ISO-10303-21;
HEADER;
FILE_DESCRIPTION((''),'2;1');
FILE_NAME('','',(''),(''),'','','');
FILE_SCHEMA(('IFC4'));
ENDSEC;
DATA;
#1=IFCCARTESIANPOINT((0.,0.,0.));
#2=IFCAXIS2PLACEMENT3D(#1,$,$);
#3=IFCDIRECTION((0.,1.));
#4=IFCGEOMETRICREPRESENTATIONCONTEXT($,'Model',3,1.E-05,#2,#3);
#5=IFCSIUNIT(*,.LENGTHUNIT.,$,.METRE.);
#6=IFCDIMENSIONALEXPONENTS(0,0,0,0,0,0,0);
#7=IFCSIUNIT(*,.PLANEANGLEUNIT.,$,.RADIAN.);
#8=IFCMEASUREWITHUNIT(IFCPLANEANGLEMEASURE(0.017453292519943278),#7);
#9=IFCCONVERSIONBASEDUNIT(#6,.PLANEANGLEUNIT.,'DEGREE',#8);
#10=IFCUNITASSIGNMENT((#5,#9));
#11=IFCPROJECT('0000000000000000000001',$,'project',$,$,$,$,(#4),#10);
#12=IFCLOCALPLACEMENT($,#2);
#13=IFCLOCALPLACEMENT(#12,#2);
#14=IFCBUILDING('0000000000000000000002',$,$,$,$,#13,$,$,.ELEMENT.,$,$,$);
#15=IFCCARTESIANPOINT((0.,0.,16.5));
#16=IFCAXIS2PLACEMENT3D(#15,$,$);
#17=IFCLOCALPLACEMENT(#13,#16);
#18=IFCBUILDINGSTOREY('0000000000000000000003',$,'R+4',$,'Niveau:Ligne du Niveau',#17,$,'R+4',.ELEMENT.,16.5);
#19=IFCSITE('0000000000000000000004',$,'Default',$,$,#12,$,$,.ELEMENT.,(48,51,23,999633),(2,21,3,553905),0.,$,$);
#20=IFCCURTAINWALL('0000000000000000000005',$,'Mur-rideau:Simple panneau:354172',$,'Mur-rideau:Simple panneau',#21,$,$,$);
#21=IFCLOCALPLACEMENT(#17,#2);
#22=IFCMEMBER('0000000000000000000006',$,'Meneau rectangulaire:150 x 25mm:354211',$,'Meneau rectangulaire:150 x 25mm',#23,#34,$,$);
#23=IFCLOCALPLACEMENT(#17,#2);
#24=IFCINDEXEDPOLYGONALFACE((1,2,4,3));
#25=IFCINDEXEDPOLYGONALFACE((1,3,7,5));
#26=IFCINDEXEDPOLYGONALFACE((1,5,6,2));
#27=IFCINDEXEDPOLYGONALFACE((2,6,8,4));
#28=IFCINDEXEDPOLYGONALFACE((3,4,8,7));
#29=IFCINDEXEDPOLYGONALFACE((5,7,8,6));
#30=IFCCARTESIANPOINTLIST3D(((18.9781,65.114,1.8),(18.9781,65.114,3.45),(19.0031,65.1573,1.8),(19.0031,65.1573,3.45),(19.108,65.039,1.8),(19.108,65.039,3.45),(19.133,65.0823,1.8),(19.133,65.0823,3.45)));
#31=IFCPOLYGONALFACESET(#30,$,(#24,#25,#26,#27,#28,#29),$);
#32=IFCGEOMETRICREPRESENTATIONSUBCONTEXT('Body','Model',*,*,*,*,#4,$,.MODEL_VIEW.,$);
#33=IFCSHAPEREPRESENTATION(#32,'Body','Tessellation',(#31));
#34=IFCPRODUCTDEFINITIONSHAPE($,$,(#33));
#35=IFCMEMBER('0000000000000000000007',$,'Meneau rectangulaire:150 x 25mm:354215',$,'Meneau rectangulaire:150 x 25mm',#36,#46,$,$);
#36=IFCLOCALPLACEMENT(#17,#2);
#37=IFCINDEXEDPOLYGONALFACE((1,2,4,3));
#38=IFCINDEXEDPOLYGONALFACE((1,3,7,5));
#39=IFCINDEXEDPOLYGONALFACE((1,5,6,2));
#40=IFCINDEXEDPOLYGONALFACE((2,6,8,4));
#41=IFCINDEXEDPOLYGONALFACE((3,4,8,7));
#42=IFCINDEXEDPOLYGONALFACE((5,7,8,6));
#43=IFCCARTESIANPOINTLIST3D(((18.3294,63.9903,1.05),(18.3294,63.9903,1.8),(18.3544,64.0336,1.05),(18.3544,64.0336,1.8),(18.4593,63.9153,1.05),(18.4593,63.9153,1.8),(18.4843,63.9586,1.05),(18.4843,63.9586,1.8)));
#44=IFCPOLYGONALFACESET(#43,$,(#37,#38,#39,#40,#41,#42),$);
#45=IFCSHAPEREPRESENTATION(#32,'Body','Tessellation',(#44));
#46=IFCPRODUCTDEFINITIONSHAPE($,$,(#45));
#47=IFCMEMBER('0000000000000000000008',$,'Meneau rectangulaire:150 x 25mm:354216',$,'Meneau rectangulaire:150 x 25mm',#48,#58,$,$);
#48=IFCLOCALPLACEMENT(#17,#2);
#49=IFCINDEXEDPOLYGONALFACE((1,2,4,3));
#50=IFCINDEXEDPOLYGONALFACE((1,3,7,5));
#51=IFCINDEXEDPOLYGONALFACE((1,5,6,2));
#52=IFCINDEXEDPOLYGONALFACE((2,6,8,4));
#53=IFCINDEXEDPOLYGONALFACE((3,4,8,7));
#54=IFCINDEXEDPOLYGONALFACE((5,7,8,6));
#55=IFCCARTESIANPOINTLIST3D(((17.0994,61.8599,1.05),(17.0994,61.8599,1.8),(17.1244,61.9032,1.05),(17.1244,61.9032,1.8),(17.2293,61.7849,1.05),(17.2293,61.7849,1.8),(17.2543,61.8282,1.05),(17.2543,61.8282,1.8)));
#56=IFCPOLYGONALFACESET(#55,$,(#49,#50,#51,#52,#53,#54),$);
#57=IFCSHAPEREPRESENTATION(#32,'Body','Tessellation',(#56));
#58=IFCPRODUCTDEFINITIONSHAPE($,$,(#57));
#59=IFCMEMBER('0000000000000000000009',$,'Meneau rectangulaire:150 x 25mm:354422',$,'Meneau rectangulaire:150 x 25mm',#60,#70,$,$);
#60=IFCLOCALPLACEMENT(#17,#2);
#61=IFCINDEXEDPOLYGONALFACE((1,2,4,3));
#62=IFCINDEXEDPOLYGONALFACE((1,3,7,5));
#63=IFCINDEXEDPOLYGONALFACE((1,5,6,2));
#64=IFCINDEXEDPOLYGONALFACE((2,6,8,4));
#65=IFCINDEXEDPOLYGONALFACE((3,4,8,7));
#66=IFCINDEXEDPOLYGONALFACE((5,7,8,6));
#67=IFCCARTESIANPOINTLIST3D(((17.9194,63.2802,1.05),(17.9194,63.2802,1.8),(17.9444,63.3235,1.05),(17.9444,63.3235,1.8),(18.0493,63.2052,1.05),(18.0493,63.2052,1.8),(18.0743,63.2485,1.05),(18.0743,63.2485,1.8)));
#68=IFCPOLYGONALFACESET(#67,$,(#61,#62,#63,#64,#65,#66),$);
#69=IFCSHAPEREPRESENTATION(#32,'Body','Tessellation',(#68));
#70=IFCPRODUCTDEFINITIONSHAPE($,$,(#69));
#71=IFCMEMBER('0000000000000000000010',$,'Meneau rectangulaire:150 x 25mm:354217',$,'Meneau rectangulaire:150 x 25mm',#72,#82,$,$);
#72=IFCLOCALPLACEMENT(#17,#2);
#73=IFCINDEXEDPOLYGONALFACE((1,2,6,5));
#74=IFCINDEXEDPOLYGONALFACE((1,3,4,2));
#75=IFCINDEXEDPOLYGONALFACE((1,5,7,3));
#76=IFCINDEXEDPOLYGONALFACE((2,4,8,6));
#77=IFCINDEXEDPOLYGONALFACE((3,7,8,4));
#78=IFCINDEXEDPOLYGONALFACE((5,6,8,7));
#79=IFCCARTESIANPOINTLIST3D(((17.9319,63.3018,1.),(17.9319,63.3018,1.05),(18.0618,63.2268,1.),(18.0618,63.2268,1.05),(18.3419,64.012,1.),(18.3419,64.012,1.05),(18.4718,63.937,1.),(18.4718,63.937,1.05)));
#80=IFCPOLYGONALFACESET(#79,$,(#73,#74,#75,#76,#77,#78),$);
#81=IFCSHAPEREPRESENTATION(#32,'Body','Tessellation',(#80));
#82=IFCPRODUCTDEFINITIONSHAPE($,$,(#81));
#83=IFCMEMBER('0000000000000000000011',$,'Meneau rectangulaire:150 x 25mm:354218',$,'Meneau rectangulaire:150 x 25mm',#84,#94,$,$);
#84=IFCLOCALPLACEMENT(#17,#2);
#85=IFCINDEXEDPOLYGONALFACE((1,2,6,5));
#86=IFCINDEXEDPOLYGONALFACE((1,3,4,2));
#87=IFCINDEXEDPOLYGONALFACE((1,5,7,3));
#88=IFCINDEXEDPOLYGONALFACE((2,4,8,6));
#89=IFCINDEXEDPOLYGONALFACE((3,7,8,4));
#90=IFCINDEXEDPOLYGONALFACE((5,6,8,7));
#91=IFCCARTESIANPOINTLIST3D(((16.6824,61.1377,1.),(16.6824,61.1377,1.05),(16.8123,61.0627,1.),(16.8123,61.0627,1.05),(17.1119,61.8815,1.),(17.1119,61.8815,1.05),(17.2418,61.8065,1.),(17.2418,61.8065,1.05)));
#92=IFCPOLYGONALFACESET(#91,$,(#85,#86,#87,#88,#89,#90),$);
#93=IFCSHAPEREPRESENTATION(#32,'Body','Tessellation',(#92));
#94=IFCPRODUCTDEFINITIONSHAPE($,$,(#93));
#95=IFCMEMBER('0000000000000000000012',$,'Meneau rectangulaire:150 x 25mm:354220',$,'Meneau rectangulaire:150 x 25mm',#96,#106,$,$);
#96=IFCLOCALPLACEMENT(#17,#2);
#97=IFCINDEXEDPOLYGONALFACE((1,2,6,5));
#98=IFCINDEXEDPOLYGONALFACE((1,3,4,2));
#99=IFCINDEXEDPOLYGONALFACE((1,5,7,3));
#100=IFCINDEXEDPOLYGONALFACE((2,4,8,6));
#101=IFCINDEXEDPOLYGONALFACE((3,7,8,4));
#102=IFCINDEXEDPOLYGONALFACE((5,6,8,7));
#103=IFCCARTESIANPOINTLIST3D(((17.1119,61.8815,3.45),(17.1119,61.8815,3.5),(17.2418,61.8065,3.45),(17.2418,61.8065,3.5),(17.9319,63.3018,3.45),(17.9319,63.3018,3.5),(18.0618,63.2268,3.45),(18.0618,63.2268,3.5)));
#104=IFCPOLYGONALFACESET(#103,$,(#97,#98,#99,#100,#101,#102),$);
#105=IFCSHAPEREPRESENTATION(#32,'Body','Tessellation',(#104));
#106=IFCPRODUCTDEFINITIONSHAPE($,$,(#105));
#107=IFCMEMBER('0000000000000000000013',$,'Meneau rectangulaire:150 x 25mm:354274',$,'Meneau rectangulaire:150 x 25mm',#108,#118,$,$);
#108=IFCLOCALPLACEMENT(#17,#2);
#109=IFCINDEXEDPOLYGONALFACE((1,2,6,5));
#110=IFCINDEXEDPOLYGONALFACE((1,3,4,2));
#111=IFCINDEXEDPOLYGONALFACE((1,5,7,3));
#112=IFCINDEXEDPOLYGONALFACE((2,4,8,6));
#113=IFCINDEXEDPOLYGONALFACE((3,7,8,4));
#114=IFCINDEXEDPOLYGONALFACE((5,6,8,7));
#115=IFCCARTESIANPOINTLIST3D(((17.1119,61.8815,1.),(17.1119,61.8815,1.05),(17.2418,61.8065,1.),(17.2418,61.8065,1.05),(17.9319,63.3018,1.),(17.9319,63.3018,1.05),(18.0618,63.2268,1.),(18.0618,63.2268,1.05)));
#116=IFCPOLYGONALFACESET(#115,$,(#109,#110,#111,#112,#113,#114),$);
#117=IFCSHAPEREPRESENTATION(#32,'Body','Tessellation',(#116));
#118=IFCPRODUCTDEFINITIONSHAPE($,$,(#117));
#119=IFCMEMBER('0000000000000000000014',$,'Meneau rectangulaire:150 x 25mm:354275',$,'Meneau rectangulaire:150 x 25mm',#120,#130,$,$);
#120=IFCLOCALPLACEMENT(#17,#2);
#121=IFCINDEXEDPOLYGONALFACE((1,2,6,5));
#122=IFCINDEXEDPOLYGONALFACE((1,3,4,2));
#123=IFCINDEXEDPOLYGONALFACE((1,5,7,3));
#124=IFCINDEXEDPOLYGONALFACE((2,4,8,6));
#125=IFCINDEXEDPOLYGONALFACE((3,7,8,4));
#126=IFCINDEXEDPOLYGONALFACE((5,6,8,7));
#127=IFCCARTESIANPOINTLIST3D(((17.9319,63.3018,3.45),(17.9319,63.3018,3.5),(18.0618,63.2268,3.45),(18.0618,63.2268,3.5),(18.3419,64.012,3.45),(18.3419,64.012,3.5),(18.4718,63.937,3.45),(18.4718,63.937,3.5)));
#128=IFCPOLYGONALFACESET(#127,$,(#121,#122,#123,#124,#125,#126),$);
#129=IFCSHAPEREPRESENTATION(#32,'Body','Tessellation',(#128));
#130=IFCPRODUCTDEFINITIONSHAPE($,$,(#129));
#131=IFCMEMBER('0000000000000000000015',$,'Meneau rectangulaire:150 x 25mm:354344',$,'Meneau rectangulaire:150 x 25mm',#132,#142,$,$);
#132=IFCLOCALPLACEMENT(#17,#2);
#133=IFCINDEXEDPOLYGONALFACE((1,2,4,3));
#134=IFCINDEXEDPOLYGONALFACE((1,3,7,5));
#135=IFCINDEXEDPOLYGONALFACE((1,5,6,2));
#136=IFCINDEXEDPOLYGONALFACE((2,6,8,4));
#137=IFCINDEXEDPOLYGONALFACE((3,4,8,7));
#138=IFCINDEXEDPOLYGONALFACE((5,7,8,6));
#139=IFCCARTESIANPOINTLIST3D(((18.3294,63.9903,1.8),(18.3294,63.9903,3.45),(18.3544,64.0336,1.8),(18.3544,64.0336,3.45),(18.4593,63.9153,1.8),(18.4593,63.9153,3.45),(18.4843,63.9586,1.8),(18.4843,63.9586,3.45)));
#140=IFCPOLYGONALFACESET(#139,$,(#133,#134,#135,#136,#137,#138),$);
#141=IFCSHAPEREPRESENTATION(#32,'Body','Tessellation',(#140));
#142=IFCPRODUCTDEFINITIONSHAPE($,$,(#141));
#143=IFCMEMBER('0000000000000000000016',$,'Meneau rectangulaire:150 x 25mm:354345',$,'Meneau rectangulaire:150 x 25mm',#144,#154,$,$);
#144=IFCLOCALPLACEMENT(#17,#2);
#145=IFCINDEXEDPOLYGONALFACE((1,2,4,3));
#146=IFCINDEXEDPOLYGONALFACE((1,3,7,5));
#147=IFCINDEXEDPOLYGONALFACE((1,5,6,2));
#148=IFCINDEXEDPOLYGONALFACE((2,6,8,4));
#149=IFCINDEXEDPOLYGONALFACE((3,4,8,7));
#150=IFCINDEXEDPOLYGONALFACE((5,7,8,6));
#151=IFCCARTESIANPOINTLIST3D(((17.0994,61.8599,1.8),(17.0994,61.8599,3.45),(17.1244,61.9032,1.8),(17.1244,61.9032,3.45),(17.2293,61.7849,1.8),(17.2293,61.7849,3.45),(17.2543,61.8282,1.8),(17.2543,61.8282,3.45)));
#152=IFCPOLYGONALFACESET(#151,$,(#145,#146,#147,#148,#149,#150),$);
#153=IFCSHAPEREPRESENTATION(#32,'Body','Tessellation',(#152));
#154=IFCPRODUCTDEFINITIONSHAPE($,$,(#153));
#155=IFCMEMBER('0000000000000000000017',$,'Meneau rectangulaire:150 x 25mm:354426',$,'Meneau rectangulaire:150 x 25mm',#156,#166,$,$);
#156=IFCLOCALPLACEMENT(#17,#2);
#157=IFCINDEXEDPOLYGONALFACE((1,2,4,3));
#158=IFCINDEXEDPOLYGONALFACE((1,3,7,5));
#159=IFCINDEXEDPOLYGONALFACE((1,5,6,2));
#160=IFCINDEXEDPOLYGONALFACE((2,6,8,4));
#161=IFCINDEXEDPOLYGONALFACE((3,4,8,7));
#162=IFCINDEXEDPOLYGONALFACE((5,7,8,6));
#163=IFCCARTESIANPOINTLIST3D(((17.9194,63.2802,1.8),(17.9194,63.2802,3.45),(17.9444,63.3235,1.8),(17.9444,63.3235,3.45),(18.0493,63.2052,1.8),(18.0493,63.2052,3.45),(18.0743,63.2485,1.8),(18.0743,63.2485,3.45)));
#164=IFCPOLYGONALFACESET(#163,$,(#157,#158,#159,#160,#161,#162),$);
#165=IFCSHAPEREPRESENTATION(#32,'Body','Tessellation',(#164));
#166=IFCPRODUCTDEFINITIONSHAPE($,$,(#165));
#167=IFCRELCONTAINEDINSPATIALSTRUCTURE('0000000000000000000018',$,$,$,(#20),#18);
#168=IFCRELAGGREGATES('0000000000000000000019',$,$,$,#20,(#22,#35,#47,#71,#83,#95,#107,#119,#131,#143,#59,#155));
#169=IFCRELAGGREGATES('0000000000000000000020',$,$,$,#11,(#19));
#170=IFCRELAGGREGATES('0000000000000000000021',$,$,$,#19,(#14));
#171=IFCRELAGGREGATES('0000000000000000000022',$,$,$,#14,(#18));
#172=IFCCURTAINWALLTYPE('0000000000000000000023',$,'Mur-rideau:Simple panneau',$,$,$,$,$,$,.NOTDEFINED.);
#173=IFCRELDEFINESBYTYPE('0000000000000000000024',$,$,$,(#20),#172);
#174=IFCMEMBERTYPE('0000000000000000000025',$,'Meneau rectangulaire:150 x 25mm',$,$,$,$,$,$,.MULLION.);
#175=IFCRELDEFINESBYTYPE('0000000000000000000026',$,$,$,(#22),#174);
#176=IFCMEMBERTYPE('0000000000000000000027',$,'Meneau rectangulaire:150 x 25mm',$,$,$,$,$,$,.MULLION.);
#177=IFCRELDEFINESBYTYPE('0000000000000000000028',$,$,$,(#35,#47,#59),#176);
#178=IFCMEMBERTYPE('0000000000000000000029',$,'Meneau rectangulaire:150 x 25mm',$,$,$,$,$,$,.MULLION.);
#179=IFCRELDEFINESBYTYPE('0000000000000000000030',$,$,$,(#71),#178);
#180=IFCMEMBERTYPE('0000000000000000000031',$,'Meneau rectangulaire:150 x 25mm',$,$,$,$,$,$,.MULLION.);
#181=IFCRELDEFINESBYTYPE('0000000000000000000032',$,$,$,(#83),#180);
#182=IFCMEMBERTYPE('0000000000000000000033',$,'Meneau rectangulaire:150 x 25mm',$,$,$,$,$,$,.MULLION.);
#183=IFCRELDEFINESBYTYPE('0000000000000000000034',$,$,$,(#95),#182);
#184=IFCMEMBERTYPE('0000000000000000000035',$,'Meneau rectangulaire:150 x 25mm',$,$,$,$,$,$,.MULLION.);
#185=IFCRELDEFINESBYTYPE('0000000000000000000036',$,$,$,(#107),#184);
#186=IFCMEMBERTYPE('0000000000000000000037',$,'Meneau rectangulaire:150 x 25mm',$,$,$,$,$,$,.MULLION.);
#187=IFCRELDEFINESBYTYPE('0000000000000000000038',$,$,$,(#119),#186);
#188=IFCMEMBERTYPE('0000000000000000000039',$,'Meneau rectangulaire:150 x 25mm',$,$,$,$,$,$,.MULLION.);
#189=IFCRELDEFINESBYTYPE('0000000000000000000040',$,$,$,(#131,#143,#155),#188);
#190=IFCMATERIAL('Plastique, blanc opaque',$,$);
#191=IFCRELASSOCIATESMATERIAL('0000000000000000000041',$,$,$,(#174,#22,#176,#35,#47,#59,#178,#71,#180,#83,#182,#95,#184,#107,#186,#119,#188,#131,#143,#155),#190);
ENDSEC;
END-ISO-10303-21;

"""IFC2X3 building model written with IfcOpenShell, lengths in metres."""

from ifc_helpers import new_model, entity, si_unit, converted_unit, direction, frame, origin, origin_2d_with_axis, place, context, subcontext, project, spatial, rectangle, extrude, source, transform, mapped, material, type_object, type_shapes, element, aggregate, save


model = new_model("IFC2X3")

# Units and contexts
model_context = context("Model", 3, precision=1e-05, world=origin(), true_north=direction((0.0, 1.0)))
body_context = subcontext(model_context, "Body", "Model", "MODEL_VIEW")
ifc_project = project(units=[si_unit("LENGTHUNIT", "METRE"), converted_unit("PLANEANGLEUNIT", "DEGREE", entity("IfcPlaneAngleMeasure", 0.017453292519943278), si_unit("PLANEANGLEUNIT", "RADIAN"), dimensions=[0, 0, 0, 0, 0, 0, 0])], contexts=[model_context])

# Site, building, storey
site_placement = place(None, origin())
site = spatial("IfcSite", under=ifc_project, at=site_placement, Name="Default", CompositionType="ELEMENT", RefLatitude=(48, 51, 23, 999633), RefLongitude=(2, 21, 3, 553905), RefElevation=0.0)
building_placement = place(site_placement, origin())
building = spatial("IfcBuilding", under=site, at=building_placement, CompositionType="ELEMENT")
storey_placement = place(building_placement, frame((0.0, 0.0, 16.5)))
storey = spatial("IfcBuildingStorey", under=building, at=storey_placement, Name="R+4", ObjectType="Niveau:Ligne du Niveau", LongName="R+4", CompositionType="ELEMENT", Elevation=16.5)

# Curtain wall, members
curtain_wall_type = type_object("IfcCurtainWallType", Name="Mur-rideau:Simple panneau", PredefinedType="NOTDEFINED")
curtain_wall_placement = place(storey_placement, frame((0.0, 0.0, -16.5)))
curtain_wall = element("IfcCurtainWall", 1, at=curtain_wall_placement, inside=storey, type_object=curtain_wall_type, Name="Mur-rideau:Simple panneau:354172", ObjectType="Mur-rideau:Simple panneau")
ifc_material_1 = material(Name="Plastique, blanc opaque")
member_type_1 = type_object("IfcMemberType", Name="Meneau rectangulaire:150 x 25mm", PredefinedType="MULLION", material=ifc_material_1)
shared_shape_1 = source(origin(), body_context, "Body", "SweptSolid", [
    extrude(rectangle(XDim=0.05, YDim=0.15, at=origin_2d_with_axis()), frame((-0.025, 0.0, -1.65), z_axis=(0.0, 0.0, 1.0), x_axis=(-1.0, 0.0, 0.0)), (0.0, 0.0, 1.0), 1.65),
])
type_shapes(member_type_1, [shared_shape_1])
member_1_placement = place(curtain_wall_placement, frame((19.0681, 65.1198, 19.95), z_axis=(0.0, 0.0, 1.0), x_axis=(0.5, 0.866025, 0.0)))
member_1 = element("IfcMember", 2, at=member_1_placement, type_object=member_type_1, material=ifc_material_1, Name="Meneau rectangulaire:150 x 25mm:354211", ObjectType="Meneau rectangulaire:150 x 25mm", context=body_context, shape_type="MappedRepresentation", body=[
    mapped(shared_shape_1, transform((0.0, 0.0, 0.0), scale=1.0)),
])
member_type_2 = type_object("IfcMemberType", Name="Meneau rectangulaire:150 x 25mm", PredefinedType="MULLION", material=ifc_material_1)
shared_shape_2 = source(origin(), body_context, "Body", "SweptSolid", [
    extrude(rectangle(XDim=0.05, YDim=0.15, at=origin_2d_with_axis()), frame((0.0, 0.0, -0.75), z_axis=(0.0, 0.0, 1.0), x_axis=(-1.0, 0.0, 0.0)), (0.0, 0.0, 1.0), 0.75),
])
type_shapes(member_type_2, [shared_shape_2])
member_2_placement = place(curtain_wall_placement, frame((18.4068, 63.9745, 17.55), z_axis=(0.0, 0.0, -1.0), x_axis=(-0.5, -0.866025, 0.0)))
member_2 = element("IfcMember", 3, at=member_2_placement, type_object=member_type_2, material=ifc_material_1, Name="Meneau rectangulaire:150 x 25mm:354215", ObjectType="Meneau rectangulaire:150 x 25mm", context=body_context, shape_type="MappedRepresentation", body=[
    mapped(shared_shape_2, transform((0.0, 0.0, 0.0), scale=1.0)),
])
member_3_placement = place(curtain_wall_placement, frame((17.1768, 61.844, 17.55), z_axis=(0.0, 0.0, -1.0), x_axis=(-0.5, -0.866025, 0.0)))
member_3 = element("IfcMember", 4, at=member_3_placement, type_object=member_type_2, material=ifc_material_1, Name="Meneau rectangulaire:150 x 25mm:354216", ObjectType="Meneau rectangulaire:150 x 25mm", context=body_context, shape_type="MappedRepresentation", body=[
    mapped(shared_shape_2, transform((0.0, 0.0, 0.0), scale=1.0)),
])
member_4_placement = place(curtain_wall_placement, frame((17.9968, 63.2643, 17.55), z_axis=(0.0, 0.0, -1.0), x_axis=(-0.5, -0.866025, 0.0)))
member_4 = element("IfcMember", 5, at=member_4_placement, type_object=member_type_2, material=ifc_material_1, Name="Meneau rectangulaire:150 x 25mm:354422", ObjectType="Meneau rectangulaire:150 x 25mm", context=body_context, shape_type="MappedRepresentation", body=[
    mapped(shared_shape_2, transform((0.0, 0.0, 0.0), scale=1.0)),
])
member_type_3 = type_object("IfcMemberType", Name="Meneau rectangulaire:150 x 25mm", PredefinedType="MULLION", material=ifc_material_1)
shared_shape_3 = source(origin(), body_context, "Body", "SweptSolid", [
    extrude(rectangle(XDim=0.05, YDim=0.15, at=origin_2d_with_axis()), frame((-0.025, 0.0, -0.82), z_axis=(0.0, 0.0, 1.0), x_axis=(-1.0, 0.0, 0.0)), (0.0, 0.0, 1.0), 0.82),
])
type_shapes(member_type_3, [shared_shape_3])
member_5_placement = place(curtain_wall_placement, frame((18.4068, 63.9745, 17.5), z_axis=(0.5, 0.866025, 0.0), x_axis=(0.0, 0.0, -1.0)))
member_5 = element("IfcMember", 6, at=member_5_placement, type_object=member_type_3, material=ifc_material_1, Name="Meneau rectangulaire:150 x 25mm:354217", ObjectType="Meneau rectangulaire:150 x 25mm", context=body_context, shape_type="MappedRepresentation", body=[
    mapped(shared_shape_3, transform((0.0, 0.0, 0.0), scale=1.0)),
])
member_type_4 = type_object("IfcMemberType", Name="Meneau rectangulaire:150 x 25mm", PredefinedType="MULLION", material=ifc_material_1)
shared_shape_4 = source(origin(), body_context, "Body", "SweptSolid", [
    extrude(rectangle(XDim=0.05, YDim=0.15, at=origin_2d_with_axis()), frame((-0.025, 0.0, -0.8589), z_axis=(0.0, 0.0, 1.0), x_axis=(-1.0, 0.0, 0.0)), (0.0, 0.0, 1.0), 0.8589),
])
type_shapes(member_type_4, [shared_shape_4])
member_6_placement = place(curtain_wall_placement, frame((17.1768, 61.844, 17.5), z_axis=(0.5, 0.866025, 0.0), x_axis=(0.0, 0.0, -1.0)))
member_6 = element("IfcMember", 7, at=member_6_placement, type_object=member_type_4, material=ifc_material_1, Name="Meneau rectangulaire:150 x 25mm:354218", ObjectType="Meneau rectangulaire:150 x 25mm", context=body_context, shape_type="MappedRepresentation", body=[
    mapped(shared_shape_4, transform((0.0, 0.0, 0.0), scale=1.0)),
])
member_type_5 = type_object("IfcMemberType", Name="Meneau rectangulaire:150 x 25mm", PredefinedType="MULLION", material=ifc_material_1)
shared_shape_5 = source(origin(), body_context, "Body", "SweptSolid", [
    extrude(rectangle(XDim=0.05, YDim=0.15, at=origin_2d_with_axis()), frame((-0.025, 0.0, -1.64), z_axis=(0.0, 0.0, 1.0), x_axis=(-1.0, 0.0, 0.0)), (0.0, 0.0, 1.0), 1.64),
])
type_shapes(member_type_5, [shared_shape_5])
member_7_placement = place(curtain_wall_placement, frame((17.1768, 61.844, 20.0), z_axis=(-0.5, -0.866025, 0.0), x_axis=(0.0, 0.0, 1.0)))
member_7 = element("IfcMember", 8, at=member_7_placement, type_object=member_type_5, material=ifc_material_1, Name="Meneau rectangulaire:150 x 25mm:354220", ObjectType="Meneau rectangulaire:150 x 25mm", context=body_context, shape_type="MappedRepresentation", body=[
    mapped(shared_shape_5, transform((0.0, 0.0, 0.0), scale=1.0)),
])
member_type_6 = type_object("IfcMemberType", Name="Meneau rectangulaire:150 x 25mm", PredefinedType="MULLION", material=ifc_material_1)
shared_shape_6 = source(origin(), body_context, "Body", "SweptSolid", [
    extrude(rectangle(XDim=0.05, YDim=0.15, at=origin_2d_with_axis()), frame((-0.025, 0.0, -1.64), z_axis=(0.0, 0.0, 1.0), x_axis=(-1.0, 0.0, 0.0)), (0.0, 0.0, 1.0), 1.64),
])
type_shapes(member_type_6, [shared_shape_6])
member_8_placement = place(curtain_wall_placement, frame((17.9968, 63.2643, 17.5), z_axis=(0.5, 0.866025, 0.0), x_axis=(0.0, 0.0, -1.0)))
member_8 = element("IfcMember", 9, at=member_8_placement, type_object=member_type_6, material=ifc_material_1, Name="Meneau rectangulaire:150 x 25mm:354274", ObjectType="Meneau rectangulaire:150 x 25mm", context=body_context, shape_type="MappedRepresentation", body=[
    mapped(shared_shape_6, transform((0.0, 0.0, 0.0), scale=1.0)),
])
member_type_7 = type_object("IfcMemberType", Name="Meneau rectangulaire:150 x 25mm", PredefinedType="MULLION", material=ifc_material_1)
shared_shape_7 = source(origin(), body_context, "Body", "SweptSolid", [
    extrude(rectangle(XDim=0.05, YDim=0.15, at=origin_2d_with_axis()), frame((-0.025, 0.0, -0.82), z_axis=(0.0, 0.0, 1.0), x_axis=(-1.0, 0.0, 0.0)), (0.0, 0.0, 1.0), 0.82),
])
type_shapes(member_type_7, [shared_shape_7])
member_9_placement = place(curtain_wall_placement, frame((17.9968, 63.2643, 20.0), z_axis=(-0.5, -0.866025, 0.0), x_axis=(0.0, 0.0, 1.0)))
member_9 = element("IfcMember", 10, at=member_9_placement, type_object=member_type_7, material=ifc_material_1, Name="Meneau rectangulaire:150 x 25mm:354275", ObjectType="Meneau rectangulaire:150 x 25mm", context=body_context, shape_type="MappedRepresentation", body=[
    mapped(shared_shape_7, transform((0.0, 0.0, 0.0), scale=1.0)),
])
member_type_8 = type_object("IfcMemberType", Name="Meneau rectangulaire:150 x 25mm", PredefinedType="MULLION", material=ifc_material_1)
shared_shape_8 = source(origin(), body_context, "Body", "SweptSolid", [
    extrude(rectangle(XDim=0.05, YDim=0.15, at=origin_2d_with_axis()), frame((0.0, 0.0, -1.65), z_axis=(0.0, 0.0, 1.0), x_axis=(-1.0, 0.0, 0.0)), (0.0, 0.0, 1.0), 1.65),
])
type_shapes(member_type_8, [shared_shape_8])
member_10_placement = place(curtain_wall_placement, frame((18.4068, 63.9745, 18.3), z_axis=(0.0, 0.0, -1.0), x_axis=(-0.5, -0.866025, 0.0)))
member_10 = element("IfcMember", 11, at=member_10_placement, type_object=member_type_8, material=ifc_material_1, Name="Meneau rectangulaire:150 x 25mm:354344", ObjectType="Meneau rectangulaire:150 x 25mm", context=body_context, shape_type="MappedRepresentation", body=[
    mapped(shared_shape_8, transform((0.0, 0.0, 0.0), scale=1.0)),
])
member_11_placement = place(curtain_wall_placement, frame((17.1768, 61.844, 18.3), z_axis=(0.0, 0.0, -1.0), x_axis=(-0.5, -0.866025, 0.0)))
member_11 = element("IfcMember", 12, at=member_11_placement, type_object=member_type_8, material=ifc_material_1, Name="Meneau rectangulaire:150 x 25mm:354345", ObjectType="Meneau rectangulaire:150 x 25mm", context=body_context, shape_type="MappedRepresentation", body=[
    mapped(shared_shape_8, transform((0.0, 0.0, 0.0), scale=1.0)),
])
member_12_placement = place(curtain_wall_placement, frame((17.9968, 63.2643, 18.3), z_axis=(0.0, 0.0, -1.0), x_axis=(-0.5, -0.866025, 0.0)))
member_12 = element("IfcMember", 13, at=member_12_placement, type_object=member_type_8, material=ifc_material_1, Name="Meneau rectangulaire:150 x 25mm:354426", ObjectType="Meneau rectangulaire:150 x 25mm", context=body_context, shape_type="MappedRepresentation", body=[
    mapped(shared_shape_8, transform((0.0, 0.0, 0.0), scale=1.0)),
])
aggregate(curtain_wall, [member_1, member_2, member_3, member_5, member_6, member_7, member_8, member_9, member_10, member_11, member_4, member_12])

save(model, "model.ifc")
